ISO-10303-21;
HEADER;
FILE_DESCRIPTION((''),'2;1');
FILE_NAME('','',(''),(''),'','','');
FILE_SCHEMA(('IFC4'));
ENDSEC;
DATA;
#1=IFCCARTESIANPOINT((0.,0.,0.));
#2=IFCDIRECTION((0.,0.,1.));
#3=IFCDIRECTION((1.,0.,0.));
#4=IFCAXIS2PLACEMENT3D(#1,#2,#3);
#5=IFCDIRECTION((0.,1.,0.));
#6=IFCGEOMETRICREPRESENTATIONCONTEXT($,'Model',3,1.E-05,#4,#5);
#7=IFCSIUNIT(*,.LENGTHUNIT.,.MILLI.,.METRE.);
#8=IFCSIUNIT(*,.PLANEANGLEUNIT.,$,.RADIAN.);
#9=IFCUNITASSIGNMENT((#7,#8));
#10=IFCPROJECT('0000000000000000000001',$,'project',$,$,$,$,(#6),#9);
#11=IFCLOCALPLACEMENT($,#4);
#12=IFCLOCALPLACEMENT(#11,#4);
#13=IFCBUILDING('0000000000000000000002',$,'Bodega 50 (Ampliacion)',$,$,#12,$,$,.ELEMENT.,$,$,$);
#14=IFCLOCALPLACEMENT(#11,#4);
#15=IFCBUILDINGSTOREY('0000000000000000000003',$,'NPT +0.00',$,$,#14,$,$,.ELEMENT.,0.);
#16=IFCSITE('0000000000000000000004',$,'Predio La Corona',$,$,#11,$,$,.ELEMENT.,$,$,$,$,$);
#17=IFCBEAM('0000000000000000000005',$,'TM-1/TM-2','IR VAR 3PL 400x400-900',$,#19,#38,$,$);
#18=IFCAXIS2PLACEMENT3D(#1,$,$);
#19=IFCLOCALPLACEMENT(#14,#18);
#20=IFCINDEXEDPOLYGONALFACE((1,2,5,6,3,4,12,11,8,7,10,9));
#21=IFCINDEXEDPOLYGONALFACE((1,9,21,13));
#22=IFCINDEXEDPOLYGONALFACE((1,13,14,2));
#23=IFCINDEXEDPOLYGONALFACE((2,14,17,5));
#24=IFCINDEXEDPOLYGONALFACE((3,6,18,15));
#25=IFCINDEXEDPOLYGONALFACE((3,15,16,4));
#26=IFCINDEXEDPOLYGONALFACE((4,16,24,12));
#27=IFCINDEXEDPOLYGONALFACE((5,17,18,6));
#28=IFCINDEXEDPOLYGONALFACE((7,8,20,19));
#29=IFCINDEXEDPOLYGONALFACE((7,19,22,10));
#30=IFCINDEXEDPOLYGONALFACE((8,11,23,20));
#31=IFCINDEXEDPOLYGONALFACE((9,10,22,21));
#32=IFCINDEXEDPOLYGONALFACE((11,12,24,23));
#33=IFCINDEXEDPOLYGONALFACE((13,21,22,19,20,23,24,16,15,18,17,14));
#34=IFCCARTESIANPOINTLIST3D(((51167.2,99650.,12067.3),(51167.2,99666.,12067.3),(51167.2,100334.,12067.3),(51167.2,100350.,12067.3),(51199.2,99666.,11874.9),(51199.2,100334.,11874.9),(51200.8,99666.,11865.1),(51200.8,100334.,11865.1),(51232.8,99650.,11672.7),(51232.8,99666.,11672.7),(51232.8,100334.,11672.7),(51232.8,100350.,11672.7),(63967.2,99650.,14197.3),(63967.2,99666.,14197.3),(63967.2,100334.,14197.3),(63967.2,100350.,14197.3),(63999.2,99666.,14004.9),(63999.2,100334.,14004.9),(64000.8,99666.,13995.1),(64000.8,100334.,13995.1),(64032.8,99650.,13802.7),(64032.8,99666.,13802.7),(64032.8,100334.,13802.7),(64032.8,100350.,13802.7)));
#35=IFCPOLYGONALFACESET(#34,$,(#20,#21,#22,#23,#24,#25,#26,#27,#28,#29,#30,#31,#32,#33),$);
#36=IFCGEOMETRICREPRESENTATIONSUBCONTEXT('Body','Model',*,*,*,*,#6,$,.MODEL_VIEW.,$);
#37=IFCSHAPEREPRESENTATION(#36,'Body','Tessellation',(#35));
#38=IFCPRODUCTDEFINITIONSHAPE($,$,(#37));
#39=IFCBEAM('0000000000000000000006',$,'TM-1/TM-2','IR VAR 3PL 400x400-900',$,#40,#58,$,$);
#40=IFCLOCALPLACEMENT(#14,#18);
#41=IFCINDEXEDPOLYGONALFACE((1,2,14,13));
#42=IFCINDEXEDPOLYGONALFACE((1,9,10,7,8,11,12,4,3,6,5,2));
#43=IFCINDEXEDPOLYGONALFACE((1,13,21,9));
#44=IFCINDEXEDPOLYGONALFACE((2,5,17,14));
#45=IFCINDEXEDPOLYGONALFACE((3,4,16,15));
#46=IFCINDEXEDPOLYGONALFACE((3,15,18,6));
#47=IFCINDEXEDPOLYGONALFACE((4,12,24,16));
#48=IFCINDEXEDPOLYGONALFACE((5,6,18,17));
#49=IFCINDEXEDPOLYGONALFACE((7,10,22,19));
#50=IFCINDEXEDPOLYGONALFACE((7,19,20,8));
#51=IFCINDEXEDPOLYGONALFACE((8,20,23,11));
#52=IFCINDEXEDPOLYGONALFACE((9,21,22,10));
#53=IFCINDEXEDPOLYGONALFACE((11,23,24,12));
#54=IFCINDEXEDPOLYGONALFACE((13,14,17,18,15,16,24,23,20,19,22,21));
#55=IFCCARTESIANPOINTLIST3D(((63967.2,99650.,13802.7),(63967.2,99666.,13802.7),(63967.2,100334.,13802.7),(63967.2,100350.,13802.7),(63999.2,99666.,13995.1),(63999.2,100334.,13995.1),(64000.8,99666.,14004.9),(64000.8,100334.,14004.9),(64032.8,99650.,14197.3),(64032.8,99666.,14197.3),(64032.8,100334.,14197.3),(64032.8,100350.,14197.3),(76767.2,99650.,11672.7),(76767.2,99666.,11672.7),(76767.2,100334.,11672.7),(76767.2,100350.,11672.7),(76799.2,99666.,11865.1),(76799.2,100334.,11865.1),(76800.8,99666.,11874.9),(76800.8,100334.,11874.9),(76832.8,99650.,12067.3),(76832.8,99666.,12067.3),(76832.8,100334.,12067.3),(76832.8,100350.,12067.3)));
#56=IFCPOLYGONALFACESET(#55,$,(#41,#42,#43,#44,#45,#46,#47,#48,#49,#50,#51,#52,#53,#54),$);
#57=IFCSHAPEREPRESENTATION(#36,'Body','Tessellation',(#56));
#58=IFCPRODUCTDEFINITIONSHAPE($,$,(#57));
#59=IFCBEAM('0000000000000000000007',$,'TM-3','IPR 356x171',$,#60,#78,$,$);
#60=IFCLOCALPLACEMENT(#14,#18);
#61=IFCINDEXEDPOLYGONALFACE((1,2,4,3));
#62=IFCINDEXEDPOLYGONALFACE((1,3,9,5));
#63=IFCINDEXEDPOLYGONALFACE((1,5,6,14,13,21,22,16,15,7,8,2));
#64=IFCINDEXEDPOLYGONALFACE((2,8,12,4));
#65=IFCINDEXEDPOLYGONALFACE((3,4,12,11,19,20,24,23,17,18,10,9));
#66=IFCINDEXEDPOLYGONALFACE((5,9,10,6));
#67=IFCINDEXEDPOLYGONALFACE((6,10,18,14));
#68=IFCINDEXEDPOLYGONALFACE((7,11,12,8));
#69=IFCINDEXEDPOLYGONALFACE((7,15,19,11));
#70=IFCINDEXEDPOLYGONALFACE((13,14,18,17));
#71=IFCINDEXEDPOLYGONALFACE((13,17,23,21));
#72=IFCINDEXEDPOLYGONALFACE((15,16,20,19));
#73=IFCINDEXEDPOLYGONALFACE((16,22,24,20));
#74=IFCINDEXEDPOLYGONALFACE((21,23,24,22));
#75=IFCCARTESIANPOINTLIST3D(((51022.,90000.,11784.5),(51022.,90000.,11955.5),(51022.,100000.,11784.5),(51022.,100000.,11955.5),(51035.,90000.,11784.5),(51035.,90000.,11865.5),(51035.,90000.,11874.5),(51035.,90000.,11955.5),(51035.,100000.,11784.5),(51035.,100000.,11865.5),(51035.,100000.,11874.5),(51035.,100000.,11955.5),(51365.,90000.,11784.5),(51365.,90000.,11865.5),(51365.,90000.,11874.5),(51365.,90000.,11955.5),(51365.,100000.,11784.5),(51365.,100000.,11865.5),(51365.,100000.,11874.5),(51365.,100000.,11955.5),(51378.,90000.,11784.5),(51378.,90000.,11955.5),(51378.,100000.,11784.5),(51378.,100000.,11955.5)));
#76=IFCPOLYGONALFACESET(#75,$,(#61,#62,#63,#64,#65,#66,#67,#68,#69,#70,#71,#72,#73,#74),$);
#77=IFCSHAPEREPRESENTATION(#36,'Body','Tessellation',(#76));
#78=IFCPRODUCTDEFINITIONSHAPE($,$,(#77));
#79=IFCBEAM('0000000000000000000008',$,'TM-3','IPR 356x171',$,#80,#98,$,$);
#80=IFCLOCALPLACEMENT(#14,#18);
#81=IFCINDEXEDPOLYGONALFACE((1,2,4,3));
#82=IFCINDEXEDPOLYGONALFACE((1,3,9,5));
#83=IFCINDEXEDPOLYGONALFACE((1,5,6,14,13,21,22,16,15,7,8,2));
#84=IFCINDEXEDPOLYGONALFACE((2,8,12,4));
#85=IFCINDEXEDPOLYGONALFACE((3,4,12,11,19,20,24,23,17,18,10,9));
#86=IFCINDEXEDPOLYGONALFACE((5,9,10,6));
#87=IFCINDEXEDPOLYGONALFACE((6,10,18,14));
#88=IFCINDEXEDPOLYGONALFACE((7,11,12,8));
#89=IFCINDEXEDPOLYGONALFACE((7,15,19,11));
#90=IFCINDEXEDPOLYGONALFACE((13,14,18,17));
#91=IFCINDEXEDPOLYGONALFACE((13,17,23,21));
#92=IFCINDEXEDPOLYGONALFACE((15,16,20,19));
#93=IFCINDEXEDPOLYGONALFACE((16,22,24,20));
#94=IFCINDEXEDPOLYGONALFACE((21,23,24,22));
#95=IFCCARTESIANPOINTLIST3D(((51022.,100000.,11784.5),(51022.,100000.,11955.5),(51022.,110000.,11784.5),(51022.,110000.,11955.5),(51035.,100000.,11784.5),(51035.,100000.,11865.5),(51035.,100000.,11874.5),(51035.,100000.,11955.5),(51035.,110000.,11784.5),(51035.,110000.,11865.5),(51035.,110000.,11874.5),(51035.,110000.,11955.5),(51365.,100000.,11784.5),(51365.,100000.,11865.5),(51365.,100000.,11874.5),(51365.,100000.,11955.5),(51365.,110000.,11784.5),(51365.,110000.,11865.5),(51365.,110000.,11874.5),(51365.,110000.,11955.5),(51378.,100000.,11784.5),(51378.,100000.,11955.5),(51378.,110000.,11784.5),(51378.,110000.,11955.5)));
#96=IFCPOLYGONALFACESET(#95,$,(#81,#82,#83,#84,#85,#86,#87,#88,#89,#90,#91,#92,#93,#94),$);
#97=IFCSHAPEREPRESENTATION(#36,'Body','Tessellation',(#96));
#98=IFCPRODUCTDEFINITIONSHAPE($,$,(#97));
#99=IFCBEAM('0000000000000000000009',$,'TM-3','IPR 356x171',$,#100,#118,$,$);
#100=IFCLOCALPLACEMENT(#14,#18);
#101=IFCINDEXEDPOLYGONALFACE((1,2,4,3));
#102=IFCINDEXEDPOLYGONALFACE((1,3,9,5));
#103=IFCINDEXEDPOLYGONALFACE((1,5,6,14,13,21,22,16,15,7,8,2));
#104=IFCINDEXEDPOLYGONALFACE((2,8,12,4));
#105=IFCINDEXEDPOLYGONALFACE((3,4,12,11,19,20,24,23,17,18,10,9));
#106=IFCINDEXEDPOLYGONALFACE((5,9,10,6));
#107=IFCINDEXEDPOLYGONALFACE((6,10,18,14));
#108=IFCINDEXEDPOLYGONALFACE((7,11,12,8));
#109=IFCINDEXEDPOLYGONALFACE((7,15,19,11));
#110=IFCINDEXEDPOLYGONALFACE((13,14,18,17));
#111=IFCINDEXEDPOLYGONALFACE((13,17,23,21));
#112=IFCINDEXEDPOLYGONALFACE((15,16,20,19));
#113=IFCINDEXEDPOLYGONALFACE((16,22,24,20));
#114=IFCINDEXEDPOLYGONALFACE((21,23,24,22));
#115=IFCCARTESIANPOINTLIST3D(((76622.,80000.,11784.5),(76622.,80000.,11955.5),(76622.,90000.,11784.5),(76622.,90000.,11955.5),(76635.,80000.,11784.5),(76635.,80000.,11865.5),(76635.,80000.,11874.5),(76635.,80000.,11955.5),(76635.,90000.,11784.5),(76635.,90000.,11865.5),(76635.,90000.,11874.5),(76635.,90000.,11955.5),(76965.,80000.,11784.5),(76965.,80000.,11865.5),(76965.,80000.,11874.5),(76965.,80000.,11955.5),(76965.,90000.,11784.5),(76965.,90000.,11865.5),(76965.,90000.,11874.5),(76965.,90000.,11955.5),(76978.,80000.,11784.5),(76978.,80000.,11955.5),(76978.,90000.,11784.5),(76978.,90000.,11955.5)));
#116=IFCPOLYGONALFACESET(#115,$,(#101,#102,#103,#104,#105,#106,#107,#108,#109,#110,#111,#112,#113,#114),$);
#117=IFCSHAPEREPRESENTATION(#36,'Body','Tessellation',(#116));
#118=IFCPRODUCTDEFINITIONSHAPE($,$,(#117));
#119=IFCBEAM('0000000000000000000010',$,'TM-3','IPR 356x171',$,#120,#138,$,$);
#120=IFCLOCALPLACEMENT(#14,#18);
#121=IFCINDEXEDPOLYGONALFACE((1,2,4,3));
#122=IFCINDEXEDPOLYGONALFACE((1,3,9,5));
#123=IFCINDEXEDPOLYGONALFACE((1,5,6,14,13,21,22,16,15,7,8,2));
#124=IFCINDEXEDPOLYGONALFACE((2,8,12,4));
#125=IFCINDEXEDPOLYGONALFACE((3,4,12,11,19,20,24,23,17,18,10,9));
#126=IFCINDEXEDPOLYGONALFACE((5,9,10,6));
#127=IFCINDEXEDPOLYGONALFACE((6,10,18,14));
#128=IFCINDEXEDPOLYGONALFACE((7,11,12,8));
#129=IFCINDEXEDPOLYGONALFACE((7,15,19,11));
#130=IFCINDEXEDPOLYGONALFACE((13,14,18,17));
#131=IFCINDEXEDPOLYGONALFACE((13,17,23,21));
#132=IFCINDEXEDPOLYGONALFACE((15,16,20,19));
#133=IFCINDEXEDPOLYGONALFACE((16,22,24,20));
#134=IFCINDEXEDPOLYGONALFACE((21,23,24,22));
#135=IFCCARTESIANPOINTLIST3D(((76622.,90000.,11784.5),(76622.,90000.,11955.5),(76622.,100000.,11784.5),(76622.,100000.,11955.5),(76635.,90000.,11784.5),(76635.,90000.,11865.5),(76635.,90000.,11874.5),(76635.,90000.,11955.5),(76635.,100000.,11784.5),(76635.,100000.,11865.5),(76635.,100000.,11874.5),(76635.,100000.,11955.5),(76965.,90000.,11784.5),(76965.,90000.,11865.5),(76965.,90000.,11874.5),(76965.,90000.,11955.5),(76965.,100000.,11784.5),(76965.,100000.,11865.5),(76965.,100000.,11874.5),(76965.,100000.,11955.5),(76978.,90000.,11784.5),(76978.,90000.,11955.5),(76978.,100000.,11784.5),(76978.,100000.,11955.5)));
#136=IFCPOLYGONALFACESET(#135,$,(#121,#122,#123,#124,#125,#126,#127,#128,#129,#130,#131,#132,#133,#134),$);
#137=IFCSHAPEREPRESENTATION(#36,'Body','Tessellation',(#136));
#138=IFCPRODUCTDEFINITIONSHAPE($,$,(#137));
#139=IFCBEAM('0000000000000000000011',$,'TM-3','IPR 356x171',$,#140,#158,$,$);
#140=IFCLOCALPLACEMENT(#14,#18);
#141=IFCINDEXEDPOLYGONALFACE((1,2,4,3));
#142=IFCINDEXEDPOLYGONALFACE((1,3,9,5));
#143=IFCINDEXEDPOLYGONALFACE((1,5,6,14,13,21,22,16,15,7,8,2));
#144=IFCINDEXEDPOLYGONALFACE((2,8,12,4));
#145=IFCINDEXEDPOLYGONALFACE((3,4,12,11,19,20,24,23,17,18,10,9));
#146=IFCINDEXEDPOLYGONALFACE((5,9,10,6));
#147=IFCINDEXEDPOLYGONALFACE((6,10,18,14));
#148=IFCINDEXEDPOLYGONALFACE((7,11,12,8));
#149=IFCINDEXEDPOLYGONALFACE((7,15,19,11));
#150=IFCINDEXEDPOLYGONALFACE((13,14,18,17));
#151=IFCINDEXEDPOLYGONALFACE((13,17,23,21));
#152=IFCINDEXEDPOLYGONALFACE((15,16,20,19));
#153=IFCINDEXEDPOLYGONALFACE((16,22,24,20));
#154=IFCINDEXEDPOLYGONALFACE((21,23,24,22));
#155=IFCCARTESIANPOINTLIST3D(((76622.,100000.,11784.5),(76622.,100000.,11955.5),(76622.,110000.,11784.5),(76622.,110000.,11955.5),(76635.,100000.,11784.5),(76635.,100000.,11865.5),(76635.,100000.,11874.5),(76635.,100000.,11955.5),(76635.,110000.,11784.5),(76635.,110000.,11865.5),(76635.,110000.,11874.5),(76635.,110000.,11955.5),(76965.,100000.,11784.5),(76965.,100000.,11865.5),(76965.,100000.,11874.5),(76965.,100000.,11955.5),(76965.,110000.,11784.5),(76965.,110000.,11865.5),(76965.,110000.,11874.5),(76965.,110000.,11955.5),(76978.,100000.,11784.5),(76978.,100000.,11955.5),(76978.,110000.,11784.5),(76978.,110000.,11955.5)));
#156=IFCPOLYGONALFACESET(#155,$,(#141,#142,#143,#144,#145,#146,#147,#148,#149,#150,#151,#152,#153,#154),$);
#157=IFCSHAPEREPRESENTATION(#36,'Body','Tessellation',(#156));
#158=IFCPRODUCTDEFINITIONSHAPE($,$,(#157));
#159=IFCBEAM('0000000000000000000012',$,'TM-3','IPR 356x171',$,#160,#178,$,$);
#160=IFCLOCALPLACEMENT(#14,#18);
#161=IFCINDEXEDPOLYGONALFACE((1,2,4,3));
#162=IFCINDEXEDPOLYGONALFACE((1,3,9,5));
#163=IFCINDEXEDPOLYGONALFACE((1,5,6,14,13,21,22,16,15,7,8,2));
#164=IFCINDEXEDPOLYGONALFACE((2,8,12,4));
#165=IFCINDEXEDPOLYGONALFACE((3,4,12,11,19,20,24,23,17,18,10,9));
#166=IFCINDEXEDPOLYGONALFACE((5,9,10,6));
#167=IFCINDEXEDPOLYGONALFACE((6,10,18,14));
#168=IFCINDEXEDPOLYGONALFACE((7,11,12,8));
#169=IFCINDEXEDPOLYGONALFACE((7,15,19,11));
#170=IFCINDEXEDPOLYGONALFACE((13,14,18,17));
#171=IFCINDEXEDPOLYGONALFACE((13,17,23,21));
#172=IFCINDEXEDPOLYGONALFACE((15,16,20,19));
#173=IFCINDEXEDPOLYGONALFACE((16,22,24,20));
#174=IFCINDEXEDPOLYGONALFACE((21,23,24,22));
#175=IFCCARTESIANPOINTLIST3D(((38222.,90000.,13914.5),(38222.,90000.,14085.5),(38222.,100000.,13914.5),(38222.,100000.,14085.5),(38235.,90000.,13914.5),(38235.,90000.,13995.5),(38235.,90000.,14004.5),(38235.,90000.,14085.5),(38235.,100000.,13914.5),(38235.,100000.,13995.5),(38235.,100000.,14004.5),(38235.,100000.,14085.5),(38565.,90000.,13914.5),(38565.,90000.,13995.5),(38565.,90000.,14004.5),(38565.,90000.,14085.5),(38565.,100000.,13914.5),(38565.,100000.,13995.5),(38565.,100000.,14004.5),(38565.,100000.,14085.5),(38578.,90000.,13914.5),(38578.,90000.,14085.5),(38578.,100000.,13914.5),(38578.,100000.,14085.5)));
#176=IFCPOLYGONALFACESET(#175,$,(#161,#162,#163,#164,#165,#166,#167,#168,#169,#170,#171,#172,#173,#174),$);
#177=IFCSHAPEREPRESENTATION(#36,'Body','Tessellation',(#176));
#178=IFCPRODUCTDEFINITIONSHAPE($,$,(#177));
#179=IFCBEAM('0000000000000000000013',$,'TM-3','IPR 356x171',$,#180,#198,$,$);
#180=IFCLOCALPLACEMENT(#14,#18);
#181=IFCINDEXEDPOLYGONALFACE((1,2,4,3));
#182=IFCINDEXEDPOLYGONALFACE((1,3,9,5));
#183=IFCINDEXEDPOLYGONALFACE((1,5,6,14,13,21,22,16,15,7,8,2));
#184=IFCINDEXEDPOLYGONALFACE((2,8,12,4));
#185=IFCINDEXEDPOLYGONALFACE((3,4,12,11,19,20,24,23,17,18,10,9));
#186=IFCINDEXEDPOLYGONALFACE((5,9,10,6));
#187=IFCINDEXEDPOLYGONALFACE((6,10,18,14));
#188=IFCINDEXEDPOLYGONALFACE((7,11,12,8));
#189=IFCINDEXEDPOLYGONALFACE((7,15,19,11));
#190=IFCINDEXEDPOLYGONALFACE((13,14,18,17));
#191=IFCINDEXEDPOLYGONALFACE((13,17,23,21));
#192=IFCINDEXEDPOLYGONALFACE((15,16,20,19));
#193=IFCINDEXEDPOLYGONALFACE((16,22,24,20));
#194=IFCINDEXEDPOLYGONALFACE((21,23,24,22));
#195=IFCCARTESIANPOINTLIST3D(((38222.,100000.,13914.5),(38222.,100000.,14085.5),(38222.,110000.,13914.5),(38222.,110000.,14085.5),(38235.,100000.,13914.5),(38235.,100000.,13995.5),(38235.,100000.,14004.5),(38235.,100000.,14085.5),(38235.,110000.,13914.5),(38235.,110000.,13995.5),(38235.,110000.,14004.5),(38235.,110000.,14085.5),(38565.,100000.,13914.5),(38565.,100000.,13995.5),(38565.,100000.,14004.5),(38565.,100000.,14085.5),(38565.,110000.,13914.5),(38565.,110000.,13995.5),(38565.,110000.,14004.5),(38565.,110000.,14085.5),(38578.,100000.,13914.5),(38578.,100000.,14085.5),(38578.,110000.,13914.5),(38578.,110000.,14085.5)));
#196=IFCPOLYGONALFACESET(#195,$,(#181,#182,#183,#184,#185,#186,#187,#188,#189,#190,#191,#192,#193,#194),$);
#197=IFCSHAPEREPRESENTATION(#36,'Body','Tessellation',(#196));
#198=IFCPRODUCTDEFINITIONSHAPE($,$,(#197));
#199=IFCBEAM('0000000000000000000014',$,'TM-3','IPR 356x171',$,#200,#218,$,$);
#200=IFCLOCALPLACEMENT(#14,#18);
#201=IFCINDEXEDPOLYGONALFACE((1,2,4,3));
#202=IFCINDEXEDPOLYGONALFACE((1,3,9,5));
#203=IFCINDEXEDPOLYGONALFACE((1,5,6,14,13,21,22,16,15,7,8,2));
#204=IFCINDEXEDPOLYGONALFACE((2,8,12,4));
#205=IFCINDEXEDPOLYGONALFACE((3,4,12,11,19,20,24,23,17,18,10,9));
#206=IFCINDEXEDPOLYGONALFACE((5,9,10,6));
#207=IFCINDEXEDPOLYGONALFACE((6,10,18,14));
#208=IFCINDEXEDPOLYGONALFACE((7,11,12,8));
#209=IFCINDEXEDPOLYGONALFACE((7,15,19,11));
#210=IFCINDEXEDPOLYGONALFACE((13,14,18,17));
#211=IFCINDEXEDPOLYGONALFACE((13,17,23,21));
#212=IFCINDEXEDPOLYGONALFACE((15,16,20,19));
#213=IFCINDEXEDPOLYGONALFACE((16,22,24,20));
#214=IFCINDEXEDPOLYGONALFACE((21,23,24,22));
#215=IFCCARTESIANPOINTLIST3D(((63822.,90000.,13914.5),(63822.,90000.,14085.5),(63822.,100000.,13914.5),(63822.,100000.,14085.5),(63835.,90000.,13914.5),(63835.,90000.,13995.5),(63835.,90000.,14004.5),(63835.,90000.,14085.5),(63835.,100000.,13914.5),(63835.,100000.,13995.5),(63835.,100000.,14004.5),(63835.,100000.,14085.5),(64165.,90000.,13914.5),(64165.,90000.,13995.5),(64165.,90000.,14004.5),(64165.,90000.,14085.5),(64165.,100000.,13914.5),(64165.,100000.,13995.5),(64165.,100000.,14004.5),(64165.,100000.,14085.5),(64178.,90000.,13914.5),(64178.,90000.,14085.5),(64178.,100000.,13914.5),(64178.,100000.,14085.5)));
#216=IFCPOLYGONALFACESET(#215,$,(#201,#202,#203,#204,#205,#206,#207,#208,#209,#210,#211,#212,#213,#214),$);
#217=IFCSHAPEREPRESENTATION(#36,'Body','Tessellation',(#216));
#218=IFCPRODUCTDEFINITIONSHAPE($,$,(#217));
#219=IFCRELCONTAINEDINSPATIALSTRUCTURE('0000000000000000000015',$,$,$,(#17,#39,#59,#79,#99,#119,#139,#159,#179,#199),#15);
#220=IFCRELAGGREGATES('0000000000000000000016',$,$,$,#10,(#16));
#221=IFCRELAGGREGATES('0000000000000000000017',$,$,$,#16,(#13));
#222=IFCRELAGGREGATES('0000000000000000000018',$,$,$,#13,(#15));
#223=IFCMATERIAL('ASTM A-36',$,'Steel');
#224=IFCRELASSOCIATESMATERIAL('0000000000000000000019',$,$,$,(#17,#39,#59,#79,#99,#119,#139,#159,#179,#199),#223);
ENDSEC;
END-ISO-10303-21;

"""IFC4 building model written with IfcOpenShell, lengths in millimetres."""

from ifc_helpers import new_model, si_unit, direction, frame, origin_with_axes, origin_2d, place, context, subcontext, project, spatial, i_section, extrude, material, element, save


model = new_model("IFC4")

# Units and contexts
model_context = context("Model", 3, precision=1e-05, world=origin_with_axes(), true_north=direction((0.0, 1.0, 0.0)))
body_context = subcontext(model_context, "Body", "Model", "MODEL_VIEW")
ifc_project = project(units=[si_unit("LENGTHUNIT", "METRE", prefix="MILLI"), si_unit("PLANEANGLEUNIT", "RADIAN")], contexts=[model_context])

# Site, building, storey
site_placement = place(None, origin_with_axes())
site = spatial("IfcSite", under=ifc_project, at=site_placement, Name="Predio La Corona", CompositionType="ELEMENT")
building_placement = place(site_placement, origin_with_axes())
building = spatial("IfcBuilding", under=site, at=building_placement, Name="Bodega 50 (Ampliacion)", CompositionType="ELEMENT")
storey_placement = place(site_placement, origin_with_axes())
storey = spatial("IfcBuildingStorey", under=building, at=storey_placement, Name="NPT +0.00", CompositionType="ELEMENT", Elevation=0.0)

# Shared definitions
ifc_material = material(Name="ASTM A-36", Category="Steel")

# Beams
for number, where, z_axis, x_axis, name in (
    (1, (51200.0, 100000.0, 11870.0), (0.986436, 0.0, 0.164149), (0.164149, 0.0, -0.986436), "TM-1/TM-2"),
    (2, (64000.0, 100000.0, 14000.0), (0.986436, 0.0, -0.164149), (-0.164149, 0.0, -0.986436), "TM-1/TM-2"),
):
    element("IfcBeam", number, at=place(storey_placement, frame(where, z_axis=z_axis, x_axis=x_axis)), inside=storey, material=ifc_material, Name=name, Description="IR VAR 3PL 400x400-900", context=body_context, shape_type="SweptSolid", body=[
        extrude(i_section(OverallWidth=400.0, OverallDepth=700.0, WebThickness=10.0, FlangeThickness=16.0, at=origin_2d()), origin_with_axes(), (0.0, 0.0, 1.0), 12976.0),
    ])
for number, where, z_axis, x_axis, name in (
    (3, (51200.0, 90000.0, 11870.0), (0.0, 1.0, 0.0), (0.0, 0.0, 1.0), "TM-3"),
    (4, (51200.0, 100000.0, 11870.0), (0.0, 1.0, 0.0), (0.0, 0.0, 1.0), "TM-3"),
    (5, (76800.0, 80000.0, 11870.0), (0.0, 1.0, 0.0), (0.0, 0.0, 1.0), "TM-3"),
    (6, (76800.0, 90000.0, 11870.0), (0.0, 1.0, 0.0), (0.0, 0.0, 1.0), "TM-3"),
    (7, (76800.0, 100000.0, 11870.0), (0.0, 1.0, 0.0), (0.0, 0.0, 1.0), "TM-3"),
    (8, (38400.0, 90000.0, 14000.0), (0.0, 1.0, 0.0), (0.0, 0.0, 1.0), "TM-3"),
    (9, (38400.0, 100000.0, 14000.0), (0.0, 1.0, 0.0), (0.0, 0.0, 1.0), "TM-3"),
    (10, (64000.0, 90000.0, 14000.0), (0.0, 1.0, 0.0), (0.0, 0.0, 1.0), "TM-3"),
):
    element("IfcBeam", number, at=place(storey_placement, frame(where, z_axis=z_axis, x_axis=x_axis)), inside=storey, material=ifc_material, Name=name, Description="IPR 356x171", context=body_context, shape_type="SweptSolid", body=[
        extrude(i_section(OverallWidth=171.0, OverallDepth=356.0, WebThickness=9.0, FlangeThickness=13.0, at=origin_2d()), origin_with_axes(), (0.0, 0.0, 1.0), 10000.0),
    ])

save(model, "model.ifc")
